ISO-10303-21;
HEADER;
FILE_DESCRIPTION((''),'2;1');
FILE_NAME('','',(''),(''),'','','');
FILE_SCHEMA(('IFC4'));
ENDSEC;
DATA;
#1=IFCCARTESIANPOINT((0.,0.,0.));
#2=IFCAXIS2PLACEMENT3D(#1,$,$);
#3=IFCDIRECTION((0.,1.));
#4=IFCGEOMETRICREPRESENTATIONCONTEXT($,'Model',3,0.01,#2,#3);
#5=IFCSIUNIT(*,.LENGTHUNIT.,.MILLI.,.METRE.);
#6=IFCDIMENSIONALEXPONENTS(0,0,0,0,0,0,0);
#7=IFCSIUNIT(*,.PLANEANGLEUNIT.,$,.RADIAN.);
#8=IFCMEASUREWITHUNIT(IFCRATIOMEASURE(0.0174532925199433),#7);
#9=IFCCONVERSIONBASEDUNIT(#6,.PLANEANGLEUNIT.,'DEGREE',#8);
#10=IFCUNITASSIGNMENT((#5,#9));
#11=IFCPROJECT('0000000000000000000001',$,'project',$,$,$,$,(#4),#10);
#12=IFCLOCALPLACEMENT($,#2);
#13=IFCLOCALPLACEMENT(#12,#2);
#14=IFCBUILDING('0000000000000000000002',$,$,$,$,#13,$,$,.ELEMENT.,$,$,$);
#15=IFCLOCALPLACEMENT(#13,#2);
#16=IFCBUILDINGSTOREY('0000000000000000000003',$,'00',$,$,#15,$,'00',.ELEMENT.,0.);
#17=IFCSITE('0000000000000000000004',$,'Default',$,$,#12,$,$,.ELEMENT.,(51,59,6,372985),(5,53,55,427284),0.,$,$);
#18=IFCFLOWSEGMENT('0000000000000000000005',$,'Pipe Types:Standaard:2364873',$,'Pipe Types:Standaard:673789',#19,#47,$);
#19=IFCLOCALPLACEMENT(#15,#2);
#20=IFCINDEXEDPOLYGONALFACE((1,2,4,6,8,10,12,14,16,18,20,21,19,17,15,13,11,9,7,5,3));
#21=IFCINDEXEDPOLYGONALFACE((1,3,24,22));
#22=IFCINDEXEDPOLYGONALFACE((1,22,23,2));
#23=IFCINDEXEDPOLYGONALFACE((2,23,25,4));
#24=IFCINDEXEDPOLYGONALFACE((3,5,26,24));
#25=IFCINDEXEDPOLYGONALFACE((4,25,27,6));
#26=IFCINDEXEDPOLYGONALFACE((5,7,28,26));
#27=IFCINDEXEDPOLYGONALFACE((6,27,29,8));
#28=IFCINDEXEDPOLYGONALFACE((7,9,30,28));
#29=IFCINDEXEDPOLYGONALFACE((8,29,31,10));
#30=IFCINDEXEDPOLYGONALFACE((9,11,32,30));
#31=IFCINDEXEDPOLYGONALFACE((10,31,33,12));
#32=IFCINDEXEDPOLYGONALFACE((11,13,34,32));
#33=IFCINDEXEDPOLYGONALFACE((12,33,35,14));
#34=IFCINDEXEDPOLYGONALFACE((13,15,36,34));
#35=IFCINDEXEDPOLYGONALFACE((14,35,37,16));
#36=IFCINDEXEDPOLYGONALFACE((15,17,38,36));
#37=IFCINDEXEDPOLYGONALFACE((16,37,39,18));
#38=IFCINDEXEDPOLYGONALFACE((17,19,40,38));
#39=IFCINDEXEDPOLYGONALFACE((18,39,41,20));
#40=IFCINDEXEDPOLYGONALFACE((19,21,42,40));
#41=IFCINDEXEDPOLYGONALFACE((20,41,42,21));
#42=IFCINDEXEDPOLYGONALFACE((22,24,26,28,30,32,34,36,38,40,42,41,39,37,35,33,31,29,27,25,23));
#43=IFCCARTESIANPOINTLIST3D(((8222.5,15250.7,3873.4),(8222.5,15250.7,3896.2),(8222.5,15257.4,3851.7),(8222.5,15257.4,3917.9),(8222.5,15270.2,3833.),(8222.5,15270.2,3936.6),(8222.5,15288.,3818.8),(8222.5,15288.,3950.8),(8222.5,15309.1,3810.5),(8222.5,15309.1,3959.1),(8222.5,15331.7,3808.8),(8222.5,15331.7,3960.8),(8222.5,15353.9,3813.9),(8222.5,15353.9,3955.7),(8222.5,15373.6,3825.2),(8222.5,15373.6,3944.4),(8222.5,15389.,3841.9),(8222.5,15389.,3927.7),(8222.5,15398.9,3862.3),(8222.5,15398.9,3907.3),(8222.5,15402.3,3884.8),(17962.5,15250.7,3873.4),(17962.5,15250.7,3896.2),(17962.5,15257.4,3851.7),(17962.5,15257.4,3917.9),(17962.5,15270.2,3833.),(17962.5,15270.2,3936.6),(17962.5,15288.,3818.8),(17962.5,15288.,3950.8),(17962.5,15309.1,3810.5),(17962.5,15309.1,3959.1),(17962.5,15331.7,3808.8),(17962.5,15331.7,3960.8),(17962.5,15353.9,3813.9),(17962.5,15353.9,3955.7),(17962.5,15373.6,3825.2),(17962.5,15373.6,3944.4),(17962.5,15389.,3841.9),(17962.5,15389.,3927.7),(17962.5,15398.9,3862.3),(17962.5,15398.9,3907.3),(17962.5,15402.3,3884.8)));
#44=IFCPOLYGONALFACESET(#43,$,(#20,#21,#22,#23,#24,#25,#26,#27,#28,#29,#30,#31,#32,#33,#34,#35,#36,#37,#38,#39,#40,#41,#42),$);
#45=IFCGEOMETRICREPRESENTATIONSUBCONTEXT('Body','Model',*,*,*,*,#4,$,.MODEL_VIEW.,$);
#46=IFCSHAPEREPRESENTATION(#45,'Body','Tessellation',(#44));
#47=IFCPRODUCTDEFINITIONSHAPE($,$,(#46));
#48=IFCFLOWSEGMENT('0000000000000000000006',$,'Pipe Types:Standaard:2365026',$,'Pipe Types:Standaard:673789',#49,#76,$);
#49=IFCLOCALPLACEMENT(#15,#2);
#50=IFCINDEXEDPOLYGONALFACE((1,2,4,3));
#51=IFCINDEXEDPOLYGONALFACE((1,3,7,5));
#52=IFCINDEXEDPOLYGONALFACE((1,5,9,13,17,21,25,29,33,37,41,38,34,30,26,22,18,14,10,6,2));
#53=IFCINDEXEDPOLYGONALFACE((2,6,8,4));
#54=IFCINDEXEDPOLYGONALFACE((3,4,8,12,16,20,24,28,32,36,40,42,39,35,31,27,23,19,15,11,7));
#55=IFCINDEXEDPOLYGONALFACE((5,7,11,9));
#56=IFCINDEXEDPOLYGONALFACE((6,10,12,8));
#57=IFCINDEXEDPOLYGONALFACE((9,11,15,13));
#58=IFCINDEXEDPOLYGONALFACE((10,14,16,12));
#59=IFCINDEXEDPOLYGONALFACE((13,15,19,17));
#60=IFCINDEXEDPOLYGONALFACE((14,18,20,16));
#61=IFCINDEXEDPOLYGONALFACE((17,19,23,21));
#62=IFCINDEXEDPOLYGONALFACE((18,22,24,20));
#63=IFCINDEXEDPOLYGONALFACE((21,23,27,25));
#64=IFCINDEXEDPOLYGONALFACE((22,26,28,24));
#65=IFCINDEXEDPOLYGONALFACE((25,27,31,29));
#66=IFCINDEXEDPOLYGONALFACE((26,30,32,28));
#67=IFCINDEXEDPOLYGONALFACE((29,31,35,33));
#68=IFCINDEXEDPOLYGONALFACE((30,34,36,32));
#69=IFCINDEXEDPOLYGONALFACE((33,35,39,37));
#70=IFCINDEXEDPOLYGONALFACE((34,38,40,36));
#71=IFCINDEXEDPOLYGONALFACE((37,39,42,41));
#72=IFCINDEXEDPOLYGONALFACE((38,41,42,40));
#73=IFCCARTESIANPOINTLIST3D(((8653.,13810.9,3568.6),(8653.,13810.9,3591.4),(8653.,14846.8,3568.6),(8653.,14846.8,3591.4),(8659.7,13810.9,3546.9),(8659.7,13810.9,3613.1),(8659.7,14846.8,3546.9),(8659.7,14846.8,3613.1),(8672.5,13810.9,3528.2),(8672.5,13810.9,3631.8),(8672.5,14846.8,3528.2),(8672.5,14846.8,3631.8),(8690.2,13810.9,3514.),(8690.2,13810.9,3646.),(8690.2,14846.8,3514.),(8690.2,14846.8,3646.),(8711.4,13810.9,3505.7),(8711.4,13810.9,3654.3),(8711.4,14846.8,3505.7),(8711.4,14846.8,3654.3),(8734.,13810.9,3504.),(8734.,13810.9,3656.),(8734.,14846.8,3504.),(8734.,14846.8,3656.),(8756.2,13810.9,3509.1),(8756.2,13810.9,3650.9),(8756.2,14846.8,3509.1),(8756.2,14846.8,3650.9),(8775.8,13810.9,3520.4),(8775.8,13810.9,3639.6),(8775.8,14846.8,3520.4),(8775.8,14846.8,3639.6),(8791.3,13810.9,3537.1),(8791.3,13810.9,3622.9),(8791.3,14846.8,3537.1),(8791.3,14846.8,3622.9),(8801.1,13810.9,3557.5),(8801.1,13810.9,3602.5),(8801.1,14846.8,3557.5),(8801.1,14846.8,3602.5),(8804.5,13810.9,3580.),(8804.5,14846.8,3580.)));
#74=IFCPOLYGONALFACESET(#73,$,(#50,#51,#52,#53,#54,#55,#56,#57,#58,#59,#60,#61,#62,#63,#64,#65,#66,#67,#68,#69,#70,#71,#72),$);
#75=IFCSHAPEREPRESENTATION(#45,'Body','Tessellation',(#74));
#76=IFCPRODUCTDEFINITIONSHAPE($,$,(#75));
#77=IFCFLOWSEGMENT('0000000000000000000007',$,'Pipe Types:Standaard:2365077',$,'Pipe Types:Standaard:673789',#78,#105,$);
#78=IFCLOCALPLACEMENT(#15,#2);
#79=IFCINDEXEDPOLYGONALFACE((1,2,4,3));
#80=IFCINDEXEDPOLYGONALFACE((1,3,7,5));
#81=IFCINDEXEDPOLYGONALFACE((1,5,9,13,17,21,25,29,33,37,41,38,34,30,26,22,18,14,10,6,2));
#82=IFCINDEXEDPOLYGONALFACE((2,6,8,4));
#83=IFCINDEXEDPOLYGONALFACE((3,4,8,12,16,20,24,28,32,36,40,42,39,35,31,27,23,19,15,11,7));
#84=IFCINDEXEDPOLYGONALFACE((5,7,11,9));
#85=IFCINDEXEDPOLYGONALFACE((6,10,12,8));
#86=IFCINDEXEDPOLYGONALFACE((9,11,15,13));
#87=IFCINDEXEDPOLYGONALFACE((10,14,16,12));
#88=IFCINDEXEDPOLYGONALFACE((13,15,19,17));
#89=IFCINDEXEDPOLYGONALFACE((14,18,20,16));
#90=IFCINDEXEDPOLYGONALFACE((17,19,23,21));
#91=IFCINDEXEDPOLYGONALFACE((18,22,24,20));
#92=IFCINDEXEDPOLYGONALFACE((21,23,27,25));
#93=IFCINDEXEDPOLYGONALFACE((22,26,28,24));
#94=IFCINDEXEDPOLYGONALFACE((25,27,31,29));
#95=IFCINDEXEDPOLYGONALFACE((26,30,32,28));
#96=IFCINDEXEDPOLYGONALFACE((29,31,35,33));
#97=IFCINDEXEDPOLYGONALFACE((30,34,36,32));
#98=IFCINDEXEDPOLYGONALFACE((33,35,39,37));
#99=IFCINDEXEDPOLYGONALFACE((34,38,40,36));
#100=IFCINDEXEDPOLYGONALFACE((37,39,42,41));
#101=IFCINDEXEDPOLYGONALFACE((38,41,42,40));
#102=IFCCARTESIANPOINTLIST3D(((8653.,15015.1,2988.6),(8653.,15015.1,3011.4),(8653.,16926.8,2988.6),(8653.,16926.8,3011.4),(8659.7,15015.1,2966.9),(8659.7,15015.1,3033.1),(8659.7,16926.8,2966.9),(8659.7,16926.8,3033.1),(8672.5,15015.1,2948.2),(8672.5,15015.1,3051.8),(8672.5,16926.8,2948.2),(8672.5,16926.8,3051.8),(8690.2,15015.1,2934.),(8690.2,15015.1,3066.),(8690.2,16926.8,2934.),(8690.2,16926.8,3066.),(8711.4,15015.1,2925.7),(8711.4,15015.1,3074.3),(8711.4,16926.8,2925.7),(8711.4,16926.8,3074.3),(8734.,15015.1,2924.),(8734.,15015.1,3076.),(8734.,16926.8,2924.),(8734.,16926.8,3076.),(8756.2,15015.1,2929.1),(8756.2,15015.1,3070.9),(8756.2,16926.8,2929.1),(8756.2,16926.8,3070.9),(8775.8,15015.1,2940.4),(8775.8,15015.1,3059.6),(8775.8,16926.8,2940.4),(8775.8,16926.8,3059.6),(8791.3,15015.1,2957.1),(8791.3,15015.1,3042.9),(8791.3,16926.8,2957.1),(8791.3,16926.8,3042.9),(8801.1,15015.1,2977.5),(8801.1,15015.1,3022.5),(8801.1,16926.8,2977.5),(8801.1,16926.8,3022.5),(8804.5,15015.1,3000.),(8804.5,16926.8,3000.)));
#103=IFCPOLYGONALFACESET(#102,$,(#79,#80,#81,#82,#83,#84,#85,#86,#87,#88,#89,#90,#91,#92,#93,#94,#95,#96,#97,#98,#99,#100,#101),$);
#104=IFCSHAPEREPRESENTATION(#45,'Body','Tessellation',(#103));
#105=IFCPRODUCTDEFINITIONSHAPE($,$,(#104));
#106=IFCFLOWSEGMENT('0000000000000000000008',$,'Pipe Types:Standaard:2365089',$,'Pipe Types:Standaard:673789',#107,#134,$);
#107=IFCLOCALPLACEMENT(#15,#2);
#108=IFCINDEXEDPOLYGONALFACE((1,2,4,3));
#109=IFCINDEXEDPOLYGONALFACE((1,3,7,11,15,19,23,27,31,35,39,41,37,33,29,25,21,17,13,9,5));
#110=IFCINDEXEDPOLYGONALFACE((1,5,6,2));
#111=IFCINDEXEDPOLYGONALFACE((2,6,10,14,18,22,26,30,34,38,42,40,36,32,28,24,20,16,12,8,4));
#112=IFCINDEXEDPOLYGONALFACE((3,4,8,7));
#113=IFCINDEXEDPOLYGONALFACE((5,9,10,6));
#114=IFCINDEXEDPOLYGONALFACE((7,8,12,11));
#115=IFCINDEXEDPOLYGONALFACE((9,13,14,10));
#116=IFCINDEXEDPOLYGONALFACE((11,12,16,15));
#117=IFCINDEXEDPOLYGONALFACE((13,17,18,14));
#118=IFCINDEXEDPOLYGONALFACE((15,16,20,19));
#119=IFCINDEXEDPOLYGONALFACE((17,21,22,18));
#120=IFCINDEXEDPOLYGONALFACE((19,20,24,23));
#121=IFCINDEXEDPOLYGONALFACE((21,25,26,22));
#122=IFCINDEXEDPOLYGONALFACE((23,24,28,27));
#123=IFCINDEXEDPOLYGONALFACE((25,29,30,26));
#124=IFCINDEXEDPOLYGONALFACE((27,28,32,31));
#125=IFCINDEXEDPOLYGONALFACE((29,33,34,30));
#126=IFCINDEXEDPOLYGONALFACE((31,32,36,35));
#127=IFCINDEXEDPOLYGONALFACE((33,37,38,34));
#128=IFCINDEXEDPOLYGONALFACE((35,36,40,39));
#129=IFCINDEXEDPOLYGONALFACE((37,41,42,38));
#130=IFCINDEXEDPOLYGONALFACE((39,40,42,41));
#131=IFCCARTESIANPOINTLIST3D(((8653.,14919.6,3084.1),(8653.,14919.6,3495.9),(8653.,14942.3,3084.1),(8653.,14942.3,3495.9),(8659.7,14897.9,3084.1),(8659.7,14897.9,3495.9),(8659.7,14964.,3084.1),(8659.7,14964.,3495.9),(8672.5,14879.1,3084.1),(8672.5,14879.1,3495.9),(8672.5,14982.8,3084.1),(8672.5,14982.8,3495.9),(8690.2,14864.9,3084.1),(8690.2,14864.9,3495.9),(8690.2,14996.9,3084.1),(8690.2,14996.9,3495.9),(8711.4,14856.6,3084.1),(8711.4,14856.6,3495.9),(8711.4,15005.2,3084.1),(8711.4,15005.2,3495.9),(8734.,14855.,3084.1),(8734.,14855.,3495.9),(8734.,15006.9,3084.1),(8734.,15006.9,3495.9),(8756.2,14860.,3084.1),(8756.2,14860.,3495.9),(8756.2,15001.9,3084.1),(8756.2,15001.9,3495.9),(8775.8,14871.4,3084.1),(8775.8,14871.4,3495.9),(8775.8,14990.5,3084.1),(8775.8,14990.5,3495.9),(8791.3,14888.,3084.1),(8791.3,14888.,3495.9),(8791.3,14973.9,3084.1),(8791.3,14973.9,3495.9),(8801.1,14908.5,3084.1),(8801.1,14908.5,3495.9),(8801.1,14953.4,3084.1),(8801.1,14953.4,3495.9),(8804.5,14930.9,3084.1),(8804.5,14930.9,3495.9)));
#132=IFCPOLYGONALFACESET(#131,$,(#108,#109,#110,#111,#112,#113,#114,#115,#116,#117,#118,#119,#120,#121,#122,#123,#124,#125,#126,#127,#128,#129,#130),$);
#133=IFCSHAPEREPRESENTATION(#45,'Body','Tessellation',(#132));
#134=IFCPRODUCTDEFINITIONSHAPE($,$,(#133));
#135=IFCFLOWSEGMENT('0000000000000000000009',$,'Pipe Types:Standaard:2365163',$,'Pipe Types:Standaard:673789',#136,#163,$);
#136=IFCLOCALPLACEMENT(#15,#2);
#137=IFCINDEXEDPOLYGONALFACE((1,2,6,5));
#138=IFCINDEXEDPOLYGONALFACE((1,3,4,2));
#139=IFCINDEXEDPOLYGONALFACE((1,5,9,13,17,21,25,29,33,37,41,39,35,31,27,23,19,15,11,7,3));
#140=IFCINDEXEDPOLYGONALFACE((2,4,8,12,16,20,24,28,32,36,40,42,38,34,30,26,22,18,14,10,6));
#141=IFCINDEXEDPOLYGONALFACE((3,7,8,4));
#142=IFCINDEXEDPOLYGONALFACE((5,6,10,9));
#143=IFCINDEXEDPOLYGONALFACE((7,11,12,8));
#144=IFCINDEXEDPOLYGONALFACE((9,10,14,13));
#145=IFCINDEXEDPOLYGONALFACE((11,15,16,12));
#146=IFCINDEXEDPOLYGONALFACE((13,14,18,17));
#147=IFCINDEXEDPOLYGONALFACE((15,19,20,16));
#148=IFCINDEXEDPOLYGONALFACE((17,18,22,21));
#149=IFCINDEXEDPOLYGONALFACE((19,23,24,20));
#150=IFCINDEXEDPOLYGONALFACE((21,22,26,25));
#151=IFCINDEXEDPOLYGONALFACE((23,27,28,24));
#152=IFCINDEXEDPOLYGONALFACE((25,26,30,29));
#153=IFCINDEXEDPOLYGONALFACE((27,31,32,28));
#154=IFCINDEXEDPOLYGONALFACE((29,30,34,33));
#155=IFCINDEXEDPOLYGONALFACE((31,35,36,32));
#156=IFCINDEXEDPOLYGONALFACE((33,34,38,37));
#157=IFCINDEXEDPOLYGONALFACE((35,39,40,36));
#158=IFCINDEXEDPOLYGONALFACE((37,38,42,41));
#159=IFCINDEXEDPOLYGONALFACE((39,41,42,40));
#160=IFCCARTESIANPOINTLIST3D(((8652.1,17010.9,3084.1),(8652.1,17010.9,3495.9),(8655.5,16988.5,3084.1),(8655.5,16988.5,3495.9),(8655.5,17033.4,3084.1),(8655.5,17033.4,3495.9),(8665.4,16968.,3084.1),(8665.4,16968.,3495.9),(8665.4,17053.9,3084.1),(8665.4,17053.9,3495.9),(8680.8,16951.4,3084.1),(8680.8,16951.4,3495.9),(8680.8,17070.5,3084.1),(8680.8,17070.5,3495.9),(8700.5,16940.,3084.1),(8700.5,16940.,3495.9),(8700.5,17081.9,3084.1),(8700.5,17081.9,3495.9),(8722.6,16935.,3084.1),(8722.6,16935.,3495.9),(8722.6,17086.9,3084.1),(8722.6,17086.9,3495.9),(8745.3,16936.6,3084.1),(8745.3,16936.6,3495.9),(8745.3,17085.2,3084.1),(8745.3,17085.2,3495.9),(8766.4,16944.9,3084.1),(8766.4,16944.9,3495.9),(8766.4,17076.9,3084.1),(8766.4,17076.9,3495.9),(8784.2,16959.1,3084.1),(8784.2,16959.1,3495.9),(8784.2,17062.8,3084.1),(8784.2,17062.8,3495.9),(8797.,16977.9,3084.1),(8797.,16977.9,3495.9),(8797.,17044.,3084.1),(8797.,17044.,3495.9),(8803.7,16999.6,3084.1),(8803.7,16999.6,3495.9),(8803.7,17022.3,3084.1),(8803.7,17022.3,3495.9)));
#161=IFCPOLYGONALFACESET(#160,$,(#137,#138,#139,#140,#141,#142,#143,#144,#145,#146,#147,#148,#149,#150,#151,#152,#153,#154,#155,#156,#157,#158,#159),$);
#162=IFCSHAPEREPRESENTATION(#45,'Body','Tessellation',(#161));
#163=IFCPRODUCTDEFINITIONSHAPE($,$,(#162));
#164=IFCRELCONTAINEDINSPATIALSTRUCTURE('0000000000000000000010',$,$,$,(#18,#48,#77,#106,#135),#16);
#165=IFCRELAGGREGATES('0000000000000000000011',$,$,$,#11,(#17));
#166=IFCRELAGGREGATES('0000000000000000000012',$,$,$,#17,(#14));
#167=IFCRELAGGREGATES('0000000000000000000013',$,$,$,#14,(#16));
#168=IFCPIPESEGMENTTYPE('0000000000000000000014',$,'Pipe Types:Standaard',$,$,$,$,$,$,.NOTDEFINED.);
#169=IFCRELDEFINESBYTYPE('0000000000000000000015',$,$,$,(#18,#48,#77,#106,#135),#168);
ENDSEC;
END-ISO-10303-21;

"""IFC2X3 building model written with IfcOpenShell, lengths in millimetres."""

from ifc_helpers import new_model, entity, si_unit, converted_unit, direction, frame, frame_2d, origin, origin_2d_with_axis, place, context, subcontext, project, spatial, circle, extrude, type_object, element, save


model = new_model("IFC2X3")

# Units and contexts
model_context = context("Model", 3, precision=0.01, world=origin(), true_north=direction((0.0, 1.0)))
body_context = subcontext(model_context, "Body", "Model", "MODEL_VIEW")
ifc_project = project(units=[si_unit("LENGTHUNIT", "METRE", prefix="MILLI"), converted_unit("PLANEANGLEUNIT", "DEGREE", entity("IfcRatioMeasure", 0.0174532925199433), si_unit("PLANEANGLEUNIT", "RADIAN"), dimensions=[0, 0, 0, 0, 0, 0, 0])], contexts=[model_context])

# Site, building, storey
site_placement = place(None, origin())
site = spatial("IfcSite", under=ifc_project, at=site_placement, Name="Default", CompositionType="ELEMENT", RefLatitude=(51, 59, 6, 372985), RefLongitude=(5, 53, 55, 427284), RefElevation=0.0)
building_placement = place(site_placement, origin())
building = spatial("IfcBuilding", under=site, at=building_placement, CompositionType="ELEMENT")
storey_placement = place(building_placement, origin())
storey = spatial("IfcBuildingStorey", under=building, at=storey_placement, Name="00", LongName="00", CompositionType="ELEMENT", Elevation=0.0)

# Flow segments
pipe_segment_type = type_object("IfcPipeSegmentType", Name="Pipe Types:Standaard", PredefinedType="NOTDEFINED")
flow_segment_1_placement = place(storey_placement, origin())
element("IfcFlowSegment", 1, at=flow_segment_1_placement, inside=storey, type_object=pipe_segment_type, Name="Pipe Types:Standaard:2364873", ObjectType="Pipe Types:Standaard:673789", context=body_context, shape_type="SweptSolid", body=[
    extrude(circle(Radius=76.2, at=frame_2d((0.0, 0.0), x_axis=(1.0, 0.0))), frame((8222.5, 15326.1, 3884.8), z_axis=(1.0, 0.0, 0.0), x_axis=(0.0, 1.0, 0.0)), (0.0, 0.0, 1.0), 9740.0),
])
flow_segment_2_placement = place(storey_placement, origin())
element("IfcFlowSegment", 2, at=flow_segment_2_placement, inside=storey, type_object=pipe_segment_type, Name="Pipe Types:Standaard:2365026", ObjectType="Pipe Types:Standaard:673789", context=body_context, shape_type="SweptSolid", body=[
    extrude(circle(Radius=76.2, at=origin_2d_with_axis()), frame((8728.3, 13810.9, 3580.0), z_axis=(0.0, 1.0, 0.0), x_axis=(1.0, 0.0, 0.0)), (0.0, 0.0, 1.0), 1035.9),
])
flow_segment_3_placement = place(storey_placement, origin())
element("IfcFlowSegment", 3, at=flow_segment_3_placement, inside=storey, type_object=pipe_segment_type, Name="Pipe Types:Standaard:2365077", ObjectType="Pipe Types:Standaard:673789", context=body_context, shape_type="SweptSolid", body=[
    extrude(circle(Radius=76.2, at=origin_2d_with_axis()), frame((8728.3, 15015.1, 3000.0), z_axis=(0.0, 1.0, 0.0), x_axis=(1.0, 0.0, 0.0)), (0.0, 0.0, 1.0), 1911.7),
])
flow_segment_4_placement = place(storey_placement, origin())
element("IfcFlowSegment", 4, at=flow_segment_4_placement, inside=storey, type_object=pipe_segment_type, Name="Pipe Types:Standaard:2365089", ObjectType="Pipe Types:Standaard:673789", context=body_context, shape_type="SweptSolid", body=[
    extrude(circle(Radius=76.2, at=origin_2d_with_axis()), frame((8728.3, 14930.9, 3084.1)), (0.0, 0.0, 1.0), 411.7),
])
flow_segment_5_placement = place(storey_placement, origin())
element("IfcFlowSegment", 5, at=flow_segment_5_placement, inside=storey, type_object=pipe_segment_type, Name="Pipe Types:Standaard:2365163", ObjectType="Pipe Types:Standaard:673789", context=body_context, shape_type="SweptSolid", body=[
    extrude(circle(Radius=76.2, at=origin_2d_with_axis()), frame((8728.3, 17010.9, 3084.1), z_axis=(0.0, 0.0, 1.0), x_axis=(-1.0, 0.0, 0.0)), (0.0, 0.0, 1.0), 411.7),
])

save(model, "model.ifc")
